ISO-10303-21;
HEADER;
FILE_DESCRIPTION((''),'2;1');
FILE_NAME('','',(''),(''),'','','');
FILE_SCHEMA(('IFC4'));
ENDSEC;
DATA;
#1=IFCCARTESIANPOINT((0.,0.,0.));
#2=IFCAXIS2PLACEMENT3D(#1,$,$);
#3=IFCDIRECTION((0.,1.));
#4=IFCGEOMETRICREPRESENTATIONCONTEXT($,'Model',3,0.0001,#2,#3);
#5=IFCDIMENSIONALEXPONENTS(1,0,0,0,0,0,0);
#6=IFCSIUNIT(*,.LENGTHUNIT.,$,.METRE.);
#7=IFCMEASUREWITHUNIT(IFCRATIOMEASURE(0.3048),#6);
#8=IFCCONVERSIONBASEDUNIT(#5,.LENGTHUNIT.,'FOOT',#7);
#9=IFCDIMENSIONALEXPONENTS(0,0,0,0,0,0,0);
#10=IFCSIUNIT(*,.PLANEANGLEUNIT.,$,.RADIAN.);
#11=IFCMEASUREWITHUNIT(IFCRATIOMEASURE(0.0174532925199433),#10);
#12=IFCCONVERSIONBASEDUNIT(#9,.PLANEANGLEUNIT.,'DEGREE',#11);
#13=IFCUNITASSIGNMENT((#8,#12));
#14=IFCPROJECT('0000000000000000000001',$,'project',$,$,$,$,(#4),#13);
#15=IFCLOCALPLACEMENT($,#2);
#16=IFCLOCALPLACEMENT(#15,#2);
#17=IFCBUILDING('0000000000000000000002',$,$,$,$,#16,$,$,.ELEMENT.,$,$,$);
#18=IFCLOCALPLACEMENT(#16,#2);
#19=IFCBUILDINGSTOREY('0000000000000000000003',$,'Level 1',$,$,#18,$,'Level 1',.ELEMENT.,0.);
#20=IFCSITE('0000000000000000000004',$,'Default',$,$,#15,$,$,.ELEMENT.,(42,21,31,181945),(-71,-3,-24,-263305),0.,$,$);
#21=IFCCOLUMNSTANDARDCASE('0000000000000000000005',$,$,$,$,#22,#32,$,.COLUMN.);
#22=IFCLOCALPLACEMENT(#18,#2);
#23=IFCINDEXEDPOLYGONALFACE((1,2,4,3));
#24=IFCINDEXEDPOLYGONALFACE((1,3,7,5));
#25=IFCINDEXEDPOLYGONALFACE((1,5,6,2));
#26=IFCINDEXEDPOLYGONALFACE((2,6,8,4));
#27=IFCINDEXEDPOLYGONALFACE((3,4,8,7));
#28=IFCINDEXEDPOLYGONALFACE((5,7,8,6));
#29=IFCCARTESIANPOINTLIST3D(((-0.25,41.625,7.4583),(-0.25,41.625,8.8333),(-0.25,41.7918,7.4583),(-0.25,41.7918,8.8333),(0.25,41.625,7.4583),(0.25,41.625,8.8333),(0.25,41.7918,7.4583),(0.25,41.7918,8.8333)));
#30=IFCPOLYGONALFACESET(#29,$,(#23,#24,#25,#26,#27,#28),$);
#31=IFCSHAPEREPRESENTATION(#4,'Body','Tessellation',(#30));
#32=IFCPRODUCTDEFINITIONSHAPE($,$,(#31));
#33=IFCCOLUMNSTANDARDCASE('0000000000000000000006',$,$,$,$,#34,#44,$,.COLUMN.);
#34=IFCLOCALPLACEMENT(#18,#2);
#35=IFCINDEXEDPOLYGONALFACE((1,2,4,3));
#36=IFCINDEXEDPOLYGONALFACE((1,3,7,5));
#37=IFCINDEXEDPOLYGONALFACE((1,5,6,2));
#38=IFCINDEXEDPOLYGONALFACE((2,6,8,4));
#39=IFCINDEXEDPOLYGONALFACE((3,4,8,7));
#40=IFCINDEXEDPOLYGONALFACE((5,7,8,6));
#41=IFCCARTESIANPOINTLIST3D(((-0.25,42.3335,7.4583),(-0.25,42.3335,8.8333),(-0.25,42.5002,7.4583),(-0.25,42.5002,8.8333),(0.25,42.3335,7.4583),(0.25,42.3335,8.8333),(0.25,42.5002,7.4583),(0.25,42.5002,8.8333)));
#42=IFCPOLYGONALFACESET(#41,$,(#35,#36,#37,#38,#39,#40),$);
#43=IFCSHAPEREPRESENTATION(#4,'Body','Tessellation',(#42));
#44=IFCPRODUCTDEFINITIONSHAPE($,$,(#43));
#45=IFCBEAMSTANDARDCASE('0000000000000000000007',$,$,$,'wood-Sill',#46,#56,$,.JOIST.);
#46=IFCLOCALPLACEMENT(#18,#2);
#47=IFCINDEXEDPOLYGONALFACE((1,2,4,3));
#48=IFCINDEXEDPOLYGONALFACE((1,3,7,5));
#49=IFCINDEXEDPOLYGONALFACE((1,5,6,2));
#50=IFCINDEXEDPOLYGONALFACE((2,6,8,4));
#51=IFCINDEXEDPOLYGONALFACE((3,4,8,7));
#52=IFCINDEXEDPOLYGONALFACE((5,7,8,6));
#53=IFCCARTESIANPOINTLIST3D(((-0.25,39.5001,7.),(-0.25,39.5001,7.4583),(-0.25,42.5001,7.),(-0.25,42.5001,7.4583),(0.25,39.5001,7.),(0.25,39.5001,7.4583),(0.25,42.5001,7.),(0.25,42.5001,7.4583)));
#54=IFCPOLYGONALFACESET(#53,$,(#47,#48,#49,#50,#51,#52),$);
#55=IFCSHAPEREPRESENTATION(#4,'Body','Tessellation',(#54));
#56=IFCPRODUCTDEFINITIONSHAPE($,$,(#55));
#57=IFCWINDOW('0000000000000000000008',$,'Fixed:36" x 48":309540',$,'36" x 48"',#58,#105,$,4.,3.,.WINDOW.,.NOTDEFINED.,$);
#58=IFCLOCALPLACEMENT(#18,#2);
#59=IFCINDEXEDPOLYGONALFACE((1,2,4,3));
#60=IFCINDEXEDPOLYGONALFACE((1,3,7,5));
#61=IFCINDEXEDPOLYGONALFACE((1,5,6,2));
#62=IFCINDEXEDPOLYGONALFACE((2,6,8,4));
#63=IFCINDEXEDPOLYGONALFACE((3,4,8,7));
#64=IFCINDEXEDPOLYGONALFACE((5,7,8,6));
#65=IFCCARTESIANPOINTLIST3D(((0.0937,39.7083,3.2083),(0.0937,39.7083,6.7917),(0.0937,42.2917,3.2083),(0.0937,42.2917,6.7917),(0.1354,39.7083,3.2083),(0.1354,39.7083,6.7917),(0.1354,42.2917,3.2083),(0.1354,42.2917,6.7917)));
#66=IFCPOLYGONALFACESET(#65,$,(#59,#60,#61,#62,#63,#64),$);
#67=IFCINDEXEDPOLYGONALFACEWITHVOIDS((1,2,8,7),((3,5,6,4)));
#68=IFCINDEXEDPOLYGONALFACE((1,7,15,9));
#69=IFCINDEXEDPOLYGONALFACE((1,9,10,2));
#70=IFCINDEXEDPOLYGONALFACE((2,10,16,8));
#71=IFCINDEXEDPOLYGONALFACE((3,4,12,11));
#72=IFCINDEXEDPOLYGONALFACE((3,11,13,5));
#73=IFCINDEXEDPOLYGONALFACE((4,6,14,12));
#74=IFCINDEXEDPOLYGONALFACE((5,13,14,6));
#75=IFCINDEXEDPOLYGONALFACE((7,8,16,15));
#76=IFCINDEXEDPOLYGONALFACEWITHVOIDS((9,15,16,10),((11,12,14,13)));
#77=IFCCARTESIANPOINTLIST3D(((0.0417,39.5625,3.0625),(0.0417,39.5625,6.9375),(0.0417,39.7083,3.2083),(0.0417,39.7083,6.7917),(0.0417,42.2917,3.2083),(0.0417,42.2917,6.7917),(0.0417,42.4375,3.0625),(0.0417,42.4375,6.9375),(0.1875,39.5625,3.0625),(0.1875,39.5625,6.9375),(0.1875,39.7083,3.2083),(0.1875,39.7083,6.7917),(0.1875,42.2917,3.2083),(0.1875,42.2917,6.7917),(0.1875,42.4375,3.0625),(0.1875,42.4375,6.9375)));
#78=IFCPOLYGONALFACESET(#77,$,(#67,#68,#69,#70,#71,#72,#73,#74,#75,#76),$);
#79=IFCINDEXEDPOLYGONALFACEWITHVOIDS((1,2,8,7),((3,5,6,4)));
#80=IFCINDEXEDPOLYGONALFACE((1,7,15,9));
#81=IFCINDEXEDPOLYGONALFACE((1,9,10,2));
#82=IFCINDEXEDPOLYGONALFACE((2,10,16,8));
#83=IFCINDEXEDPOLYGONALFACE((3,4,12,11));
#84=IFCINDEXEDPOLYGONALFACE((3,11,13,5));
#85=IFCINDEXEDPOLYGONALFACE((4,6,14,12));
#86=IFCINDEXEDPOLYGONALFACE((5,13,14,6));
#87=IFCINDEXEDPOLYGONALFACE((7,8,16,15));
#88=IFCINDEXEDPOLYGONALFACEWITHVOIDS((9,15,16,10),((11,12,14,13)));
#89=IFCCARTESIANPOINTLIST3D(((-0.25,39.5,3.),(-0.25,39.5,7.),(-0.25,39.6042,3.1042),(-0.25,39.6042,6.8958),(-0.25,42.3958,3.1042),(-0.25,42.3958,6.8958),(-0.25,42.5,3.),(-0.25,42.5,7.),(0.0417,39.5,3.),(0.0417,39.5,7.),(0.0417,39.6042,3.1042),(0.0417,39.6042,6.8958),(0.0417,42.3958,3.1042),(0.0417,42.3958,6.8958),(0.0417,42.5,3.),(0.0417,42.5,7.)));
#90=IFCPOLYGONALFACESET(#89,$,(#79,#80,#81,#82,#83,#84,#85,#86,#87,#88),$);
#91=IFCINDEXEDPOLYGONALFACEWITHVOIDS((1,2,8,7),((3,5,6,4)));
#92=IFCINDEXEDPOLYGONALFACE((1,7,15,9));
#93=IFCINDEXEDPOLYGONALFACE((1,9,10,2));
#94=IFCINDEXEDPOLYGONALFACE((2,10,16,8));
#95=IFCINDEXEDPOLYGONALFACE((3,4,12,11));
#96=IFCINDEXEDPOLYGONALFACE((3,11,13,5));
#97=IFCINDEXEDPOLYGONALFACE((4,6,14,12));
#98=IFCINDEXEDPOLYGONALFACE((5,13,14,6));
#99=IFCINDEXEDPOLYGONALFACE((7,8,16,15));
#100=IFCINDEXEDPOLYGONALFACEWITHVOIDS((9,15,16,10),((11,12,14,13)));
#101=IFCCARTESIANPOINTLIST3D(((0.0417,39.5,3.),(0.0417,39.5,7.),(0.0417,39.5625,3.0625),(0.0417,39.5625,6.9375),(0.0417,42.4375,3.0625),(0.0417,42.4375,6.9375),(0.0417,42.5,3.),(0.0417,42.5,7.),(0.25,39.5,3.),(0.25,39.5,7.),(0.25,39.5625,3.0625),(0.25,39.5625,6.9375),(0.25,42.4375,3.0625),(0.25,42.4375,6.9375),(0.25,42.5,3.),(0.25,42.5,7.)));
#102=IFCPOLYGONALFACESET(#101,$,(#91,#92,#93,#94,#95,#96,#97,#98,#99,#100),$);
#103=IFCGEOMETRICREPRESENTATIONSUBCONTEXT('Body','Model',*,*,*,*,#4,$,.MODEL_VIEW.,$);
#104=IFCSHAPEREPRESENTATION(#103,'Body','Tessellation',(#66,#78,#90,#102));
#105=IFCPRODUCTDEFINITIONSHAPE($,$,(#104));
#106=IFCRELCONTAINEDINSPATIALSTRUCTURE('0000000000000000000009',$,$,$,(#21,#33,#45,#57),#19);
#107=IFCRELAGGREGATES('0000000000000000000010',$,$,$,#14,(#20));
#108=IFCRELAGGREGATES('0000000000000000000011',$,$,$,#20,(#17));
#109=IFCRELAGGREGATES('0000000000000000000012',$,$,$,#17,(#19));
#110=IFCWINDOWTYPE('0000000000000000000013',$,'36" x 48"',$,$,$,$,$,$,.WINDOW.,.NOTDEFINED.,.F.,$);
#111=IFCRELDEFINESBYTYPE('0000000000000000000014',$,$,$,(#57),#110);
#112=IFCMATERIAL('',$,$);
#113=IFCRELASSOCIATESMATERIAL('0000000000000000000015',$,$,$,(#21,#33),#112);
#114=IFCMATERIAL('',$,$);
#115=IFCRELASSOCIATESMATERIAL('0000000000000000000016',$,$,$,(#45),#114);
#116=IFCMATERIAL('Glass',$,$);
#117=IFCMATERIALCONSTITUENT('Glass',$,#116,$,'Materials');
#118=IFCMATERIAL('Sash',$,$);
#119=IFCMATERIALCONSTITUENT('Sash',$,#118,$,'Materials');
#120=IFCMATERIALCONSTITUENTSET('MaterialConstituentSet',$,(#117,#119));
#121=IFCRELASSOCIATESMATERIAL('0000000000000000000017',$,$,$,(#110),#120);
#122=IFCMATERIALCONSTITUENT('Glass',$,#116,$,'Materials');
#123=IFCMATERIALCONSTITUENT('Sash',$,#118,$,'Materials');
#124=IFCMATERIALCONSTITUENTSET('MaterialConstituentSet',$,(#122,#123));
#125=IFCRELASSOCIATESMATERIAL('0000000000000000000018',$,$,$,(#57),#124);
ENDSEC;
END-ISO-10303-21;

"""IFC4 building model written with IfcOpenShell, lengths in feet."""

from ifc_helpers import new_model, entity, si_unit, converted_unit, direction, frame, frame_2d, origin, place, context, subcontext, project, spatial, polyline, rectangle, outline, extrude, source, transform, mapped, material, constituent, constituent_set, type_object, type_shapes, element, save


model = new_model("IFC4")

# Units and contexts
model_context = context("Model", 3, precision=0.0001, world=origin(), true_north=direction((0.0, 1.0)))
body_context = subcontext(model_context, "Body", "Model", "MODEL_VIEW")
ifc_project = project(units=[converted_unit("LENGTHUNIT", "FOOT", entity("IfcRatioMeasure", 0.3048), si_unit("LENGTHUNIT", "METRE"), dimensions=[1, 0, 0, 0, 0, 0, 0]), converted_unit("PLANEANGLEUNIT", "DEGREE", entity("IfcRatioMeasure", 0.0174532925199433), si_unit("PLANEANGLEUNIT", "RADIAN"), dimensions=[0, 0, 0, 0, 0, 0, 0])], contexts=[model_context])

# Site, building, storey
site_placement = place(None, origin())
site = spatial("IfcSite", under=ifc_project, at=site_placement, Name="Default", CompositionType="ELEMENT", RefLatitude=(42, 21, 31, 181945), RefLongitude=(-71, -3, -24, -263305), RefElevation=0.0)
building_placement = place(site_placement, origin())
building = spatial("IfcBuilding", under=site, at=building_placement, CompositionType="ELEMENT")
storey_placement = place(building_placement, origin())
storey = spatial("IfcBuildingStorey", under=building, at=storey_placement, Name="Level 1", LongName="Level 1", CompositionType="ELEMENT", Elevation=0.0)

# Columns
placement_1 = place(storey_placement, frame((0.0, -0.25, 0.0), z_axis=(0.0, 0.0, 1.0), x_axis=(0.0, 1.0, 0.0)))
ifc_material_1 = material(Name="")
for number, where, z_axis, x_axis in (
    (1, (41.9584, 0.0, 7.4583), (0.0, 0.0, 1.0), (1.0, 0.0, 0.0)),
    (2, (42.6668, 0.0, 7.4583), (0.0, 0.0, 1.0), (1.0, 0.0, 0.0)),
):
    element("IfcColumnStandardCase", number, at=place(placement_1, frame(where, z_axis=z_axis, x_axis=x_axis)), inside=storey, material=ifc_material_1, PredefinedType="COLUMN", context=model_context, shape_type="SweptSolid", body=[
        extrude(rectangle(XDim=0.1667, YDim=0.5), origin(), (0.0, 0.0, 1.0), 1.375),
    ])

# Beam
ifc_material_2 = material(Name="")
beam_placement = place(placement_1, frame((41.2501, 0.0, 7.0), z_axis=(0.0, 0.0, 1.0), x_axis=(-1.0, 0.0, 0.0)))
element("IfcBeamStandardCase", 3, at=beam_placement, inside=storey, material=ifc_material_2, ObjectType="wood-Sill", PredefinedType="JOIST", context=model_context, shape_type="SweptSolid", body=[
    extrude(rectangle(XDim=3.0, YDim=0.5), origin(), (0.0, 0.0, 1.0), 0.4583),
])

# Window
ifc_material_3 = material(Name="Glass")
ifc_constituent_1 = constituent(ifc_material_3, Name="Glass", Category="Materials")
ifc_material_4 = material(Name="Sash")
ifc_constituent_2 = constituent(ifc_material_4, Name="Sash", Category="Materials")
ifc_constituent_set_1 = constituent_set(constituents=[ifc_constituent_1, ifc_constituent_2], Name="MaterialConstituentSet")
ifc_constituent_3 = constituent(ifc_material_3, Name="Glass", Category="Materials")
ifc_constituent_4 = constituent(ifc_material_4, Name="Sash", Category="Materials")
ifc_constituent_set_2 = constituent_set(constituents=[ifc_constituent_3, ifc_constituent_4], Name="MaterialConstituentSet")
window_type = type_object("IfcWindowType", Name="36\" x 48\"", ParameterTakesPrecedence=False, PartitioningType="NOTDEFINED", PredefinedType="WINDOW", material=ifc_constituent_set_2)
shared_shape = source(origin(), body_context, "Body", "SweptSolid", [
    extrude(rectangle(XDim=0.0417, YDim=2.5833, at=frame_2d((0.0, 0.0), x_axis=(1.0, 0.0))), frame((1.5, 0.3646, 0.2083), z_axis=(0.0, 0.0, 1.0), x_axis=(0.0, 1.0, 0.0)), (0.0, 0.0, 1.0), 3.5833),
    extrude(outline(polyline([(-1.4375, -1.9375), (1.4375, -1.9375), (1.4375, 1.9375), (-1.4375, 1.9375), (-1.4375, -1.9375)]), holes=[polyline([(-1.2917, -1.7917), (-1.2917, 1.7917), (1.2917, 1.7917), (1.2917, -1.7917), (-1.2917, -1.7917)])]), frame((1.5, 0.2917, 2.0), z_axis=(0.0, 1.0, 0.0), x_axis=(1.0, 0.0, 0.0)), (0.0, 0.0, 1.0), 0.1458),
    extrude(outline(polyline([(-1.5, -2.0), (1.5, -2.0), (1.5, 2.0), (-1.5, 2.0), (-1.5, -2.0)]), holes=[polyline([(-1.3958, -1.8958), (-1.3958, 1.8958), (1.3958, 1.8958), (1.3958, -1.8958), (-1.3958, -1.8958)])]), frame((1.5, 0.0, 2.0), z_axis=(0.0, 1.0, 0.0), x_axis=(1.0, 0.0, 0.0)), (0.0, 0.0, 1.0), 0.2917),
    extrude(outline(polyline([(-2.0, -1.5), (2.0, -1.5), (2.0, 1.5), (-2.0, 1.5), (-2.0, -1.5)]), holes=[polyline([(-1.9375, -1.4375), (-1.9375, 1.4375), (1.9375, 1.4375), (1.9375, -1.4375), (-1.9375, -1.4375)])]), frame((1.5, 0.2917, 2.0), z_axis=(0.0, 1.0, 0.0), x_axis=(0.0, 0.0, -1.0)), (0.0, 0.0, 1.0), 0.2083),
])
type_shapes(window_type, [shared_shape])
placement_2 = place(placement_1, frame((42.75, 0.25, 3.0)))
window_placement = place(placement_2, frame((0.0, 0.0, 0.0), z_axis=(0.0, 0.0, 1.0), x_axis=(-1.0, 0.0, 0.0)))
element("IfcWindow", 4, at=window_placement, inside=storey, type_object=window_type, material=ifc_constituent_set_1, Name="Fixed:36\" x 48\":309540", ObjectType="36\" x 48\"", OverallHeight=4.0, OverallWidth=3.0, PartitioningType="NOTDEFINED", PredefinedType="WINDOW", context=body_context, shape_type="MappedRepresentation", body=[
    mapped(shared_shape, transform((0.0, 0.0, 0.0), scale=1.0)),
])

save(model, "model.ifc")
